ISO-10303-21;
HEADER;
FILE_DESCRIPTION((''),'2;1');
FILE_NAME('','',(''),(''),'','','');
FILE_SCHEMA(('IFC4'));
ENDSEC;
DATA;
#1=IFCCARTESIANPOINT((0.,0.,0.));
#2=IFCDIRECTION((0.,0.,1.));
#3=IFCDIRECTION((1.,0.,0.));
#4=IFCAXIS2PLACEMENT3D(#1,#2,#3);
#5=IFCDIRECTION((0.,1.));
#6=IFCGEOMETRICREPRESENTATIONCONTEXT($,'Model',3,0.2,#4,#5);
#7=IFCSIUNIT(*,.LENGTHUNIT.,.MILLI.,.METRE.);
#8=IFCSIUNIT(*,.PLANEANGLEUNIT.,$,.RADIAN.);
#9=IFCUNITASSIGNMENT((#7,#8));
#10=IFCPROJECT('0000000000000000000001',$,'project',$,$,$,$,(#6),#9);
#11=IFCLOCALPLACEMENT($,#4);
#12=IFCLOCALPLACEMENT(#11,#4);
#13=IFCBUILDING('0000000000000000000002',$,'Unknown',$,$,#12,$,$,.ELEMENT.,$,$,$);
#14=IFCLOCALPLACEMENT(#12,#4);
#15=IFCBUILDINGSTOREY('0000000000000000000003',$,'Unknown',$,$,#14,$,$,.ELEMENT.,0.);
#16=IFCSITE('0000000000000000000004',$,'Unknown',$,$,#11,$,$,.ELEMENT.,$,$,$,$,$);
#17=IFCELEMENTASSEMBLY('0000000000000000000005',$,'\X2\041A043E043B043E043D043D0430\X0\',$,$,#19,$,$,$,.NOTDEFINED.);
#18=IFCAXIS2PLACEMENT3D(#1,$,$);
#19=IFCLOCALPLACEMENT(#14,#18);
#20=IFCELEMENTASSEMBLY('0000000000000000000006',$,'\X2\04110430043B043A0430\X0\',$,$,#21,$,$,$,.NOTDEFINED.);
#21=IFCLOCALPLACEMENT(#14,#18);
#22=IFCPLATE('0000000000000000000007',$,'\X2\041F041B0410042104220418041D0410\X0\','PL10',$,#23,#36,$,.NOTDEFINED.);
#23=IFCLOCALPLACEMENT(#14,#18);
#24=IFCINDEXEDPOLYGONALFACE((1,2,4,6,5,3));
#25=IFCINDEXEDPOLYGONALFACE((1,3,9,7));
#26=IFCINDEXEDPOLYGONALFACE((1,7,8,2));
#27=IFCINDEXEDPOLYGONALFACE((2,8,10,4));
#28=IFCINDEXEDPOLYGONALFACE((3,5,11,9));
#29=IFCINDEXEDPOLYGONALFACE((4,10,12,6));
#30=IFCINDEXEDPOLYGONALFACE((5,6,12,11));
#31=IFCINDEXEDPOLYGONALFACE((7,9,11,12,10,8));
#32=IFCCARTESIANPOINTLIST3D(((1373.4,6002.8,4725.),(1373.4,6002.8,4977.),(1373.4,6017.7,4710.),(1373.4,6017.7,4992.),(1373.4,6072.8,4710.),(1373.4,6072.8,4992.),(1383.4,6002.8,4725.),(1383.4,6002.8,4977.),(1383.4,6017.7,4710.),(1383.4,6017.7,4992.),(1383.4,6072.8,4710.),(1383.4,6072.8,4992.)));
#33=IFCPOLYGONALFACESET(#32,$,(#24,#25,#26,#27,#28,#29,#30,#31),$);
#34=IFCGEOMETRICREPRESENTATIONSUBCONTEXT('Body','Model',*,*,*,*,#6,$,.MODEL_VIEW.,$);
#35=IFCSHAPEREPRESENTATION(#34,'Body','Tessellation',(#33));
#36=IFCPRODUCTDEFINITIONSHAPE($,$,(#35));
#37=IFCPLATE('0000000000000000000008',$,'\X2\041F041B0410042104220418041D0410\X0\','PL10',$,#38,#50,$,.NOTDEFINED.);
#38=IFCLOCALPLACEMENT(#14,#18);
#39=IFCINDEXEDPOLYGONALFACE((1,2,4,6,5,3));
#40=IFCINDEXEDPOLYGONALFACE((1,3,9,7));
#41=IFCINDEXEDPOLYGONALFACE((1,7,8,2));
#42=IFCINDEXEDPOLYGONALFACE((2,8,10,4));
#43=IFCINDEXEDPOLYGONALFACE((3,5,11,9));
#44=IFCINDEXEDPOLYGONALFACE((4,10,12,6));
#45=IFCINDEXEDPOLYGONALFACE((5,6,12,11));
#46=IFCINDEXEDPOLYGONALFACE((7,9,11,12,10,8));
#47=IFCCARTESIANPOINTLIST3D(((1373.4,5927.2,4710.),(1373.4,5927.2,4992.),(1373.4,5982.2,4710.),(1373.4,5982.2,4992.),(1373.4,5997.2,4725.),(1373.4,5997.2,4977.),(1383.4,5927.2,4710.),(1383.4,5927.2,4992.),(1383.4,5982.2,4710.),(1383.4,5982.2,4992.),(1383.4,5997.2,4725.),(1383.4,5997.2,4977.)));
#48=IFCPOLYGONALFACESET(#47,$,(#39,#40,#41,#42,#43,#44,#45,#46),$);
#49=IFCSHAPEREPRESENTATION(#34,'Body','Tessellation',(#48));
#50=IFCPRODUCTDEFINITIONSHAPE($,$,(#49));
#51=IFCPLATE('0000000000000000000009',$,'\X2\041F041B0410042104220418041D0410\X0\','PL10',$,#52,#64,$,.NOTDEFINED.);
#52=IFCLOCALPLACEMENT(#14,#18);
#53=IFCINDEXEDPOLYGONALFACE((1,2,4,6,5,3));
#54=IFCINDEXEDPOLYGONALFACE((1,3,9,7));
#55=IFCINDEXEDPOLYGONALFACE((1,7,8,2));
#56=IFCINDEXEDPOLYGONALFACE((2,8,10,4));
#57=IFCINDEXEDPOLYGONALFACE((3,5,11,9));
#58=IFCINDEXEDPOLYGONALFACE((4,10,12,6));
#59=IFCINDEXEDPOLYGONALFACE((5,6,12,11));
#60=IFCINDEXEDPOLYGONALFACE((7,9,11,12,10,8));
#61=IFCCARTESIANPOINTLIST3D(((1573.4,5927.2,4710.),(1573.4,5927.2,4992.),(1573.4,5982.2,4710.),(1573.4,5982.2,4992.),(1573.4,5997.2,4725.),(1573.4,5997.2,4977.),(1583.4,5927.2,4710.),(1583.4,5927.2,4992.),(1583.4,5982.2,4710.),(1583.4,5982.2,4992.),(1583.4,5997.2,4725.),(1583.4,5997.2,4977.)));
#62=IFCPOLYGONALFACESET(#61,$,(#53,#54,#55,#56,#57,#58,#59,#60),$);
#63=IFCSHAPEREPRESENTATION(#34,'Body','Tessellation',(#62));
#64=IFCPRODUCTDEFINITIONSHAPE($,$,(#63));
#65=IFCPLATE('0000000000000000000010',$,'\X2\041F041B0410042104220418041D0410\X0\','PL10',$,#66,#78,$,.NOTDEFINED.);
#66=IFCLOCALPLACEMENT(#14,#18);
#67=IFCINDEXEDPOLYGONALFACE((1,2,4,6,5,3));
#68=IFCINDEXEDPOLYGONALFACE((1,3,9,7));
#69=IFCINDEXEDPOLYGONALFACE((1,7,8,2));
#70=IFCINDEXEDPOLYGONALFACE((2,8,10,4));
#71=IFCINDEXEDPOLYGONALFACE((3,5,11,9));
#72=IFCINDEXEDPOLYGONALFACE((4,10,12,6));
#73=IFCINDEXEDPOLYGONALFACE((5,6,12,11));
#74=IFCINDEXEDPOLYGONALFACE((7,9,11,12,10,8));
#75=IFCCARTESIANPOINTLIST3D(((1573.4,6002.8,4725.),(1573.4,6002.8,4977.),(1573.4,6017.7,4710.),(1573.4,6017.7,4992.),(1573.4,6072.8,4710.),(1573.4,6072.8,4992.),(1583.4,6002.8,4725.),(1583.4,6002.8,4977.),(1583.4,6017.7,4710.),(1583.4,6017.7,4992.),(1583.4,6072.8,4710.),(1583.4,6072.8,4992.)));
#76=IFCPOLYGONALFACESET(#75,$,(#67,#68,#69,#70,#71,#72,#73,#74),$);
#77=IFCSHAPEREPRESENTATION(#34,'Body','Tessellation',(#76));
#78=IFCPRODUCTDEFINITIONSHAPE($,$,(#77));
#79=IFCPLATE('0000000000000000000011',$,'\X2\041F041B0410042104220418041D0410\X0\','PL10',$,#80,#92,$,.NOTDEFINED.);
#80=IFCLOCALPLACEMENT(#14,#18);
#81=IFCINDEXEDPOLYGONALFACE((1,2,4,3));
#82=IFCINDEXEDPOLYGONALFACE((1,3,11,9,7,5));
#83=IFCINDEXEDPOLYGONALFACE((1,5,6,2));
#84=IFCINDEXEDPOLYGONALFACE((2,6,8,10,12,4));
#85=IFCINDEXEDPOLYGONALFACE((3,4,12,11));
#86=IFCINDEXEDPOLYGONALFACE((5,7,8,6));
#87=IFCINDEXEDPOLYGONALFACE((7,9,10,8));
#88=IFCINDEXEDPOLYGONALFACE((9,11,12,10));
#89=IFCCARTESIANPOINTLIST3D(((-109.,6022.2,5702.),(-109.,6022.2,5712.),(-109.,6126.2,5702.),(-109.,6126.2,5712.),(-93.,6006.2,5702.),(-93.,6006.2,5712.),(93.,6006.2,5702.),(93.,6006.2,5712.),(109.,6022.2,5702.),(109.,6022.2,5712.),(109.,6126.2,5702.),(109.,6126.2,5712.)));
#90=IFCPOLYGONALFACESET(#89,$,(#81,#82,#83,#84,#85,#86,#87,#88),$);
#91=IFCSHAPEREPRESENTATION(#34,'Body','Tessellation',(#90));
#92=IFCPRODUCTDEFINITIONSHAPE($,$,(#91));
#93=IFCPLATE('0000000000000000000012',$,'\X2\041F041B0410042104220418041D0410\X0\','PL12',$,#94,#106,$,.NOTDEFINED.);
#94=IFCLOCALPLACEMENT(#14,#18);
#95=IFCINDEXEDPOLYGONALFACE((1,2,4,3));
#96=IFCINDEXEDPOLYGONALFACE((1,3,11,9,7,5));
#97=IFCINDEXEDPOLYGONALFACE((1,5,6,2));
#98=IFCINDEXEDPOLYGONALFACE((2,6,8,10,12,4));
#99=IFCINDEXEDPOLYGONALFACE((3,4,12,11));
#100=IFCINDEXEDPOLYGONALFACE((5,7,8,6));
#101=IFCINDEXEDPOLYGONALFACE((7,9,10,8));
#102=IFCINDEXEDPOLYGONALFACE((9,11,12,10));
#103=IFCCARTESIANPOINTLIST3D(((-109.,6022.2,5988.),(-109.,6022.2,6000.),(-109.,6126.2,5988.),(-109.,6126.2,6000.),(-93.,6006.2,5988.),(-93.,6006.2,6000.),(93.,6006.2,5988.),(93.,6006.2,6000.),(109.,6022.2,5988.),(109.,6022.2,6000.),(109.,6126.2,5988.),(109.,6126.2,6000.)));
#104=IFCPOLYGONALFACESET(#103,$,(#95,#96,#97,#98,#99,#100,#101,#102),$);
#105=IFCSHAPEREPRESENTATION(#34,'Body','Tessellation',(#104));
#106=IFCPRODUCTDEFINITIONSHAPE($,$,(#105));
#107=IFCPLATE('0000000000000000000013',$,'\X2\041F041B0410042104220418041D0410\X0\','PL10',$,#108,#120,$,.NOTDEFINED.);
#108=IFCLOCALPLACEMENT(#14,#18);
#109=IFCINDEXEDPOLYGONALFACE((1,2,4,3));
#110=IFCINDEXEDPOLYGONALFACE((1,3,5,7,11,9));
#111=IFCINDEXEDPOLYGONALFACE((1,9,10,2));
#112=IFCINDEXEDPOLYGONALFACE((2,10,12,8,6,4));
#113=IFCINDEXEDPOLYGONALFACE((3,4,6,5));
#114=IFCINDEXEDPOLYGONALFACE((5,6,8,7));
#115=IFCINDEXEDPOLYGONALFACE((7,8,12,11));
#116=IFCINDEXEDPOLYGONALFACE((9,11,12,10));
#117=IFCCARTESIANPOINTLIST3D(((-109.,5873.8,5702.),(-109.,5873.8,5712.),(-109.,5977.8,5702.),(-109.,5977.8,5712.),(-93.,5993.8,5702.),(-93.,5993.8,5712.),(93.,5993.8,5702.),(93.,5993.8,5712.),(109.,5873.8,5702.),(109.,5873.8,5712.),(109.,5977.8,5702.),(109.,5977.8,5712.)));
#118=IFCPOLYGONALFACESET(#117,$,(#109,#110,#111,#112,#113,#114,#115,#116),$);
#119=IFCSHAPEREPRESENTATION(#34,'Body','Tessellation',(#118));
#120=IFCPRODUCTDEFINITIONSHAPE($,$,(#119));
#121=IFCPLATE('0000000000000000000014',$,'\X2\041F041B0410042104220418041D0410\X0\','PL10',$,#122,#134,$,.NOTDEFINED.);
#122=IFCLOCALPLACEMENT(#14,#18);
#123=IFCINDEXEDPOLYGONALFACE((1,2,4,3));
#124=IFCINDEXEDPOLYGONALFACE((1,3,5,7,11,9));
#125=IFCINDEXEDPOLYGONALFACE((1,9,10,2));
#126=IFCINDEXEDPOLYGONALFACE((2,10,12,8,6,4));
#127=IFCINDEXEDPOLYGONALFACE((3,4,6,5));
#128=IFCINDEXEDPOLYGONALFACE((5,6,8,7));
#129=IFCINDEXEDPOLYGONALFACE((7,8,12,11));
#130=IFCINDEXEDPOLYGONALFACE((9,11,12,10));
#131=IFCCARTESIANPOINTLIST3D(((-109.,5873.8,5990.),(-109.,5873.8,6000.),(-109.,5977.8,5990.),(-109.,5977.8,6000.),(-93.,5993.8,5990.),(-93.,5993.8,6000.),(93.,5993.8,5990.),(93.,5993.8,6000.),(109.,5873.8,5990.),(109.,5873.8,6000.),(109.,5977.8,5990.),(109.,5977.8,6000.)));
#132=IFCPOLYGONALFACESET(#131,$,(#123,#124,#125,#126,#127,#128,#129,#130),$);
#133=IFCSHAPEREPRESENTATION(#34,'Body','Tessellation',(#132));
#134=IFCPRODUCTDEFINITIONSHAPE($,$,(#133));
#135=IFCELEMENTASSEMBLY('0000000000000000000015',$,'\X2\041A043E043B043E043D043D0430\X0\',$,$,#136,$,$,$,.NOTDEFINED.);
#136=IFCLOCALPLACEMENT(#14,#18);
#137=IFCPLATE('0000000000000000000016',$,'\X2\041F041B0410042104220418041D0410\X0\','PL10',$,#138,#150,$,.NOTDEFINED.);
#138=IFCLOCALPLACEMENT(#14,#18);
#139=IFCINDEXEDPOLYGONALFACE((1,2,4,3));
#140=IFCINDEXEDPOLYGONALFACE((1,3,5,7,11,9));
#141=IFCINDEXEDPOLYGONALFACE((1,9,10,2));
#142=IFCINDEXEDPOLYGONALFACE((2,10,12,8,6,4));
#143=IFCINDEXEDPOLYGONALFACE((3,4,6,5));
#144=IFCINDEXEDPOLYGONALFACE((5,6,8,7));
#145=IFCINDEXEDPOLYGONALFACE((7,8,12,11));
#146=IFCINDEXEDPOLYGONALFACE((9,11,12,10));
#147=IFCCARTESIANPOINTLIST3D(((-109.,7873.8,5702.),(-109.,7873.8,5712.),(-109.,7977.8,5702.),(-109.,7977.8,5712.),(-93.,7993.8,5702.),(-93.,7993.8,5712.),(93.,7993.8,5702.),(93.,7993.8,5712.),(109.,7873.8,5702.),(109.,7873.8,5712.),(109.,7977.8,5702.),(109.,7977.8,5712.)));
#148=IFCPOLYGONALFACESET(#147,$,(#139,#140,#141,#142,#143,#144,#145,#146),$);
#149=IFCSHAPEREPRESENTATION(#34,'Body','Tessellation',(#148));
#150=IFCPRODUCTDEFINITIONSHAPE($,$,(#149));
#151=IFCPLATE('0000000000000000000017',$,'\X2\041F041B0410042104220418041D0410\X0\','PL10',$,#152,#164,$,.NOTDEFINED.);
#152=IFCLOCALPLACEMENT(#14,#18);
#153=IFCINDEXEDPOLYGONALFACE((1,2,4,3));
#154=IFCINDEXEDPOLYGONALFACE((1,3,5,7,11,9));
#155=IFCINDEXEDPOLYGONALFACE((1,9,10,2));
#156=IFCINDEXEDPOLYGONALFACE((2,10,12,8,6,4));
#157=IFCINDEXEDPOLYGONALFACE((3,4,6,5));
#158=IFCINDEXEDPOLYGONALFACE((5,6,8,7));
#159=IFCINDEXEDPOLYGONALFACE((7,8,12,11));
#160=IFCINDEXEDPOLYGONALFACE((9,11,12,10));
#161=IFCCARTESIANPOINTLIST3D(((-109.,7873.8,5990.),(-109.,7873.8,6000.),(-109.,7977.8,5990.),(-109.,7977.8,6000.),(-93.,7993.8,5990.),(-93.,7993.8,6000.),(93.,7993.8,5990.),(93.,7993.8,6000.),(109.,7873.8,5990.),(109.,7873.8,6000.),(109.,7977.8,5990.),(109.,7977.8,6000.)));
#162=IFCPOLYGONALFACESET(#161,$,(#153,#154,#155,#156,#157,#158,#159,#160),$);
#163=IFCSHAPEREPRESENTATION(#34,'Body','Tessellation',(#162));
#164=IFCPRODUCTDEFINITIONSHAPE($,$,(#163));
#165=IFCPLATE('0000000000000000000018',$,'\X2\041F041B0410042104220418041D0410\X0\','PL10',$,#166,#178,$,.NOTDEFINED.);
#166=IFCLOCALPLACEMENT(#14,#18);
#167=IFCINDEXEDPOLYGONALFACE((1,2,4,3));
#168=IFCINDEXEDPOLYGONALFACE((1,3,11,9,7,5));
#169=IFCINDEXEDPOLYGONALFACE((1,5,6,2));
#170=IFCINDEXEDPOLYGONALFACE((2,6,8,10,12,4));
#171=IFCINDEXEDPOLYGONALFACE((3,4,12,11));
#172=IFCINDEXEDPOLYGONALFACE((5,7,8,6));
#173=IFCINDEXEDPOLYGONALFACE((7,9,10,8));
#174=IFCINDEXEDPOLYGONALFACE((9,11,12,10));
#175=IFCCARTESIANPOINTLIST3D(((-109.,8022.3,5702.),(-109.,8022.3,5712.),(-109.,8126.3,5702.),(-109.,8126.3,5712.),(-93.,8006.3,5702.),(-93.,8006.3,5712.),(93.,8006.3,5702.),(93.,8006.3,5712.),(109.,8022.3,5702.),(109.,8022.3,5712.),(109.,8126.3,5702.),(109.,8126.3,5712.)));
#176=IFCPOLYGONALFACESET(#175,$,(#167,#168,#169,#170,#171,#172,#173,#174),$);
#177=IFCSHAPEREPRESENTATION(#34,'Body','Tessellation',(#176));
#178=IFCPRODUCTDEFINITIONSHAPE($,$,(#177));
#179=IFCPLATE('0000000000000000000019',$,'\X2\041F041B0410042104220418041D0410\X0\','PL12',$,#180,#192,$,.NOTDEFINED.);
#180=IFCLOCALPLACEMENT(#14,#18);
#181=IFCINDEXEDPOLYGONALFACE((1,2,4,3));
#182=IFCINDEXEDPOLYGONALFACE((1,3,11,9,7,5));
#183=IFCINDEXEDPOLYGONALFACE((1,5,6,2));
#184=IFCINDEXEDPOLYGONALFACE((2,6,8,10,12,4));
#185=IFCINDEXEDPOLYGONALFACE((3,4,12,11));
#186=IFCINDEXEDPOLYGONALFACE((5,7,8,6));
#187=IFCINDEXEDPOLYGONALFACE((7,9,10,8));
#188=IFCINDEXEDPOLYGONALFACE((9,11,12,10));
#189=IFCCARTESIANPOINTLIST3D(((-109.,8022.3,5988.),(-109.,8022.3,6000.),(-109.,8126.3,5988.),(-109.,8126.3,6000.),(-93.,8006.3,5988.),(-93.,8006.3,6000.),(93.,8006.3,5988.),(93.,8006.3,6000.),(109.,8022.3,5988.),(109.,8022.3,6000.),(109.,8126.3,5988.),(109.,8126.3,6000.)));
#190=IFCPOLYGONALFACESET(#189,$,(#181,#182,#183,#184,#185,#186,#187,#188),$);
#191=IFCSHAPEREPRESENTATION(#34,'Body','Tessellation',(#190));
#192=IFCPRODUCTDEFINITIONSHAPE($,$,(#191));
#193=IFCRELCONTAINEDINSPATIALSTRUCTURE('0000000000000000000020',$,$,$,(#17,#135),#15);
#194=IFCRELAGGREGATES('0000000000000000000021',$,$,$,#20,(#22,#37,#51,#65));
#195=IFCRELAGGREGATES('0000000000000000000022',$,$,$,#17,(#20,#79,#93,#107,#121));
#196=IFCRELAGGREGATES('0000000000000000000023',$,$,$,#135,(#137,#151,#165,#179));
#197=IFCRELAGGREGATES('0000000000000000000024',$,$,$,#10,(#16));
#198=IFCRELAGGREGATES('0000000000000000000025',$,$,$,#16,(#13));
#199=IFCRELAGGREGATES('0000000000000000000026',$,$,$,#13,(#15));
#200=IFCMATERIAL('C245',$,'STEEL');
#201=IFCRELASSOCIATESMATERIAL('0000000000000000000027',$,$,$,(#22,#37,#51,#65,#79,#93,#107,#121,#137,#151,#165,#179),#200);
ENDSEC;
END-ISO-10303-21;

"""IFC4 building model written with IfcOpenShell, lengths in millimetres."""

from ifc_helpers import new_model, si_unit, direction, frame, origin_with_axes, place, context, subcontext, project, spatial, line, indexed_curve, outline, extrude, material, element, aggregate, save


model = new_model("IFC4")

# Units and contexts
model_context = context("Model", 3, precision=0.2, world=origin_with_axes(), true_north=direction((0.0, 1.0)))
body_context = subcontext(model_context, "Body", "Model", "MODEL_VIEW")
ifc_project = project(units=[si_unit("LENGTHUNIT", "METRE", prefix="MILLI"), si_unit("PLANEANGLEUNIT", "RADIAN")], contexts=[model_context])

# Site, building, storey
site_placement = place(None, origin_with_axes())
site = spatial("IfcSite", under=ifc_project, at=site_placement, Name="Unknown", CompositionType="ELEMENT")
building_placement = place(site_placement, origin_with_axes())
building = spatial("IfcBuilding", under=site, at=building_placement, Name="Unknown", CompositionType="ELEMENT")
storey_placement = place(building_placement, origin_with_axes())
storey = spatial("IfcBuildingStorey", under=building, at=storey_placement, Name="Unknown", CompositionType="ELEMENT", Elevation=0.0)

# Element assemblies, plates
assembly_1_placement = place(storey_placement, frame((0.0, 6000.0, 0.0), z_axis=(0.0, -1.0, 0.0), x_axis=(0.0, 0.0, 1.0)))
assembly_1 = element("IfcElementAssembly", 1, at=assembly_1_placement, inside=storey, Name="Колонна", PredefinedType="NOTDEFINED")
assembly_2_placement = place(assembly_1_placement, frame((4851.0, 0.0, 0.0), z_axis=(0.0, 0.0, 1.0), x_axis=(0.0, -1.0, 0.0)))
assembly_2 = element("IfcElementAssembly", 2, at=assembly_2_placement, Name="Балка", PredefinedType="NOTDEFINED")
ifc_material_1 = material(Name="C245", Category="STEEL")
plate_1_placement = place(assembly_2_placement, frame((1378.4, -141.0, -2.8), z_axis=(1.0, 0.0, 0.0), x_axis=(0.0, 0.0, -1.0)))
plate_1 = element("IfcPlate", 3, at=plate_1_placement, material=ifc_material_1, Name="ПЛАСТИНА", Description="PL10", PredefinedType="NOTDEFINED", context=body_context, shape_type="SolidModel", body=[
    extrude(outline(indexed_curve([(0.0, 15.0), (15.0, 0.0), (70.0, 0.0), (70.0, 282.0), (15.0, 282.0), (0.0, 267.0)], segments=[line(1, 2, 3, 4, 5, 6, 1)])), frame((0.0, 0.0, 5.0), z_axis=(0.0, 0.0, 1.0), x_axis=(1.0, 0.0, 0.0)), (0.0, 0.0, -1.0), 10.0),
])
plate_2_placement = place(assembly_2_placement, frame((1378.4, -141.0, 72.8), z_axis=(1.0, 0.0, 0.0), x_axis=(0.0, 0.0, -1.0)))
plate_2 = element("IfcPlate", 4, at=plate_2_placement, material=ifc_material_1, Name="ПЛАСТИНА", Description="PL10", PredefinedType="NOTDEFINED", context=body_context, shape_type="SolidModel", body=[
    extrude(outline(indexed_curve([(0.0, 0.0), (55.0, 0.0), (70.0, 15.0), (70.0, 267.0), (55.0, 282.0), (0.0, 282.0)], segments=[line(1, 2, 3, 4, 5, 6, 1)])), frame((0.0, 0.0, 5.0), z_axis=(0.0, 0.0, 1.0), x_axis=(1.0, 0.0, 0.0)), (0.0, 0.0, -1.0), 10.0),
])
plate_3_placement = place(assembly_2_placement, frame((1578.4, -141.0, 72.8), z_axis=(1.0, 0.0, 0.0), x_axis=(0.0, 0.0, -1.0)))
plate_3 = element("IfcPlate", 5, at=plate_3_placement, material=ifc_material_1, Name="ПЛАСТИНА", Description="PL10", PredefinedType="NOTDEFINED", context=body_context, shape_type="SolidModel", body=[
    extrude(outline(indexed_curve([(0.0, 0.0), (55.0, 0.0), (70.0, 15.0), (70.0, 267.0), (55.0, 282.0), (0.0, 282.0)], segments=[line(1, 2, 3, 4, 5, 6, 1)])), frame((0.0, 0.0, 5.0), z_axis=(0.0, 0.0, 1.0), x_axis=(1.0, 0.0, 0.0)), (0.0, 0.0, -1.0), 10.0),
])
plate_4_placement = place(assembly_2_placement, frame((1578.4, -141.0, -2.8), z_axis=(1.0, 0.0, 0.0), x_axis=(0.0, 0.0, -1.0)))
plate_4 = element("IfcPlate", 6, at=plate_4_placement, material=ifc_material_1, Name="ПЛАСТИНА", Description="PL10", PredefinedType="NOTDEFINED", context=body_context, shape_type="SolidModel", body=[
    extrude(outline(indexed_curve([(0.0, 15.0), (15.0, 0.0), (70.0, 0.0), (70.0, 282.0), (15.0, 282.0), (0.0, 267.0)], segments=[line(1, 2, 3, 4, 5, 6, 1)])), frame((0.0, 0.0, 5.0), z_axis=(0.0, 0.0, 1.0), x_axis=(1.0, 0.0, 0.0)), (0.0, 0.0, -1.0), 10.0),
])
aggregate(assembly_2, [plate_1, plate_2, plate_3, plate_4])
plate_5_placement = place(assembly_1_placement, frame((5707.0, -109.0, -126.2), z_axis=(-1.0, 0.0, 0.0), x_axis=(0.0, 0.0, 1.0)))
plate_5 = element("IfcPlate", 7, at=plate_5_placement, material=ifc_material_1, Name="ПЛАСТИНА", Description="PL10", PredefinedType="NOTDEFINED", context=body_context, shape_type="SolidModel", body=[
    extrude(outline(indexed_curve([(0.0, 0.0), (104.0, 0.0), (120.0, 16.0), (120.0, 202.0), (104.0, 218.0), (0.0, 218.0)], segments=[line(1, 2, 3, 4, 5, 6, 1)])), frame((0.0, 0.0, 5.0), z_axis=(0.0, 0.0, 1.0), x_axis=(1.0, 0.0, 0.0)), (0.0, 0.0, -1.0), 10.0),
])
plate_6_placement = place(assembly_1_placement, frame((5994.0, -109.0, -126.2), z_axis=(-1.0, 0.0, 0.0), x_axis=(0.0, 0.0, 1.0)))
plate_6 = element("IfcPlate", 8, at=plate_6_placement, material=ifc_material_1, Name="ПЛАСТИНА", Description="PL12", PredefinedType="NOTDEFINED", context=body_context, shape_type="SolidModel", body=[
    extrude(outline(indexed_curve([(0.0, 0.0), (104.0, 0.0), (120.0, 16.0), (120.0, 202.0), (104.0, 218.0), (0.0, 218.0)], segments=[line(1, 2, 3, 4, 5, 6, 1)])), frame((0.0, 0.0, 6.0), z_axis=(0.0, 0.0, 1.0), x_axis=(1.0, 0.0, 0.0)), (0.0, 0.0, -1.0), 12.0),
])
plate_7_placement = place(assembly_1_placement, frame((5707.0, -109.0, 6.2), z_axis=(-1.0, 0.0, 0.0), x_axis=(0.0, 0.0, 1.0)))
plate_7 = element("IfcPlate", 9, at=plate_7_placement, material=ifc_material_1, Name="ПЛАСТИНА", Description="PL10", PredefinedType="NOTDEFINED", context=body_context, shape_type="SolidModel", body=[
    extrude(outline(indexed_curve([(0.0, 16.0), (16.0, 0.0), (120.0, 0.0), (120.0, 218.0), (16.0, 218.0), (0.0, 202.0)], segments=[line(1, 2, 3, 4, 5, 6, 1)])), frame((0.0, 0.0, 5.0), z_axis=(0.0, 0.0, 1.0), x_axis=(1.0, 0.0, 0.0)), (0.0, 0.0, -1.0), 10.0),
])
plate_8_placement = place(assembly_1_placement, frame((5995.0, -109.0, 6.2), z_axis=(-1.0, 0.0, 0.0), x_axis=(0.0, 0.0, 1.0)))
plate_8 = element("IfcPlate", 10, at=plate_8_placement, material=ifc_material_1, Name="ПЛАСТИНА", Description="PL10", PredefinedType="NOTDEFINED", context=body_context, shape_type="SolidModel", body=[
    extrude(outline(indexed_curve([(0.0, 16.0), (16.0, 0.0), (120.0, 0.0), (120.0, 218.0), (16.0, 218.0), (0.0, 202.0)], segments=[line(1, 2, 3, 4, 5, 6, 1)])), frame((0.0, 0.0, 5.0), z_axis=(0.0, 0.0, 1.0), x_axis=(1.0, 0.0, 0.0)), (0.0, 0.0, -1.0), 10.0),
])
aggregate(assembly_1, [assembly_2, plate_5, plate_6, plate_7, plate_8])
assembly_3_placement = place(storey_placement, frame((0.0, 8000.0, 0.0), z_axis=(0.0, -1.0, 0.0), x_axis=(0.0, 0.0, 1.0)))
assembly_3 = element("IfcElementAssembly", 11, at=assembly_3_placement, inside=storey, Name="Колонна", PredefinedType="NOTDEFINED")
plate_9_placement = place(assembly_3_placement, frame((5707.0, -109.0, 6.2), z_axis=(-1.0, 0.0, 0.0), x_axis=(0.0, 0.0, 1.0)))
plate_9 = element("IfcPlate", 12, at=plate_9_placement, material=ifc_material_1, Name="ПЛАСТИНА", Description="PL10", PredefinedType="NOTDEFINED", context=body_context, shape_type="SolidModel", body=[
    extrude(outline(indexed_curve([(0.0, 16.0), (16.0, 0.0), (120.0, 0.0), (120.0, 218.0), (16.0, 218.0), (0.0, 202.0)], segments=[line(1, 2, 3, 4, 5, 6, 1)])), frame((0.0, 0.0, 5.0), z_axis=(0.0, 0.0, 1.0), x_axis=(1.0, 0.0, 0.0)), (0.0, 0.0, -1.0), 10.0),
])
plate_10_placement = place(assembly_3_placement, frame((5995.0, -109.0, 6.2), z_axis=(-1.0, 0.0, 0.0), x_axis=(0.0, 0.0, 1.0)))
plate_10 = element("IfcPlate", 13, at=plate_10_placement, material=ifc_material_1, Name="ПЛАСТИНА", Description="PL10", PredefinedType="NOTDEFINED", context=body_context, shape_type="SolidModel", body=[
    extrude(outline(indexed_curve([(0.0, 16.0), (16.0, 0.0), (120.0, 0.0), (120.0, 218.0), (16.0, 218.0), (0.0, 202.0)], segments=[line(1, 2, 3, 4, 5, 6, 1)])), frame((0.0, 0.0, 5.0), z_axis=(0.0, 0.0, 1.0), x_axis=(1.0, 0.0, 0.0)), (0.0, 0.0, -1.0), 10.0),
])
plate_11_placement = place(assembly_3_placement, frame((5707.0, -109.0, -126.2), z_axis=(-1.0, 0.0, 0.0), x_axis=(0.0, 0.0, 1.0)))
plate_11 = element("IfcPlate", 14, at=plate_11_placement, material=ifc_material_1, Name="ПЛАСТИНА", Description="PL10", PredefinedType="NOTDEFINED", context=body_context, shape_type="SolidModel", body=[
    extrude(outline(indexed_curve([(0.0, 0.0), (104.0, 0.0), (120.0, 16.0), (120.0, 202.0), (104.0, 218.0), (0.0, 218.0)], segments=[line(1, 2, 3, 4, 5, 6, 1)])), frame((0.0, 0.0, 5.0), z_axis=(0.0, 0.0, 1.0), x_axis=(1.0, 0.0, 0.0)), (0.0, 0.0, -1.0), 10.0),
])
plate_12_placement = place(assembly_3_placement, frame((5994.0, -109.0, -126.2), z_axis=(-1.0, 0.0, 0.0), x_axis=(0.0, 0.0, 1.0)))
plate_12 = element("IfcPlate", 15, at=plate_12_placement, material=ifc_material_1, Name="ПЛАСТИНА", Description="PL12", PredefinedType="NOTDEFINED", context=body_context, shape_type="SolidModel", body=[
    extrude(outline(indexed_curve([(0.0, 0.0), (104.0, 0.0), (120.0, 16.0), (120.0, 202.0), (104.0, 218.0), (0.0, 218.0)], segments=[line(1, 2, 3, 4, 5, 6, 1)])), frame((0.0, 0.0, 6.0), z_axis=(0.0, 0.0, 1.0), x_axis=(1.0, 0.0, 0.0)), (0.0, 0.0, -1.0), 12.0),
])

aggregate(assembly_3, [plate_9, plate_10, plate_11, plate_12])

save(model, "model.ifc")
